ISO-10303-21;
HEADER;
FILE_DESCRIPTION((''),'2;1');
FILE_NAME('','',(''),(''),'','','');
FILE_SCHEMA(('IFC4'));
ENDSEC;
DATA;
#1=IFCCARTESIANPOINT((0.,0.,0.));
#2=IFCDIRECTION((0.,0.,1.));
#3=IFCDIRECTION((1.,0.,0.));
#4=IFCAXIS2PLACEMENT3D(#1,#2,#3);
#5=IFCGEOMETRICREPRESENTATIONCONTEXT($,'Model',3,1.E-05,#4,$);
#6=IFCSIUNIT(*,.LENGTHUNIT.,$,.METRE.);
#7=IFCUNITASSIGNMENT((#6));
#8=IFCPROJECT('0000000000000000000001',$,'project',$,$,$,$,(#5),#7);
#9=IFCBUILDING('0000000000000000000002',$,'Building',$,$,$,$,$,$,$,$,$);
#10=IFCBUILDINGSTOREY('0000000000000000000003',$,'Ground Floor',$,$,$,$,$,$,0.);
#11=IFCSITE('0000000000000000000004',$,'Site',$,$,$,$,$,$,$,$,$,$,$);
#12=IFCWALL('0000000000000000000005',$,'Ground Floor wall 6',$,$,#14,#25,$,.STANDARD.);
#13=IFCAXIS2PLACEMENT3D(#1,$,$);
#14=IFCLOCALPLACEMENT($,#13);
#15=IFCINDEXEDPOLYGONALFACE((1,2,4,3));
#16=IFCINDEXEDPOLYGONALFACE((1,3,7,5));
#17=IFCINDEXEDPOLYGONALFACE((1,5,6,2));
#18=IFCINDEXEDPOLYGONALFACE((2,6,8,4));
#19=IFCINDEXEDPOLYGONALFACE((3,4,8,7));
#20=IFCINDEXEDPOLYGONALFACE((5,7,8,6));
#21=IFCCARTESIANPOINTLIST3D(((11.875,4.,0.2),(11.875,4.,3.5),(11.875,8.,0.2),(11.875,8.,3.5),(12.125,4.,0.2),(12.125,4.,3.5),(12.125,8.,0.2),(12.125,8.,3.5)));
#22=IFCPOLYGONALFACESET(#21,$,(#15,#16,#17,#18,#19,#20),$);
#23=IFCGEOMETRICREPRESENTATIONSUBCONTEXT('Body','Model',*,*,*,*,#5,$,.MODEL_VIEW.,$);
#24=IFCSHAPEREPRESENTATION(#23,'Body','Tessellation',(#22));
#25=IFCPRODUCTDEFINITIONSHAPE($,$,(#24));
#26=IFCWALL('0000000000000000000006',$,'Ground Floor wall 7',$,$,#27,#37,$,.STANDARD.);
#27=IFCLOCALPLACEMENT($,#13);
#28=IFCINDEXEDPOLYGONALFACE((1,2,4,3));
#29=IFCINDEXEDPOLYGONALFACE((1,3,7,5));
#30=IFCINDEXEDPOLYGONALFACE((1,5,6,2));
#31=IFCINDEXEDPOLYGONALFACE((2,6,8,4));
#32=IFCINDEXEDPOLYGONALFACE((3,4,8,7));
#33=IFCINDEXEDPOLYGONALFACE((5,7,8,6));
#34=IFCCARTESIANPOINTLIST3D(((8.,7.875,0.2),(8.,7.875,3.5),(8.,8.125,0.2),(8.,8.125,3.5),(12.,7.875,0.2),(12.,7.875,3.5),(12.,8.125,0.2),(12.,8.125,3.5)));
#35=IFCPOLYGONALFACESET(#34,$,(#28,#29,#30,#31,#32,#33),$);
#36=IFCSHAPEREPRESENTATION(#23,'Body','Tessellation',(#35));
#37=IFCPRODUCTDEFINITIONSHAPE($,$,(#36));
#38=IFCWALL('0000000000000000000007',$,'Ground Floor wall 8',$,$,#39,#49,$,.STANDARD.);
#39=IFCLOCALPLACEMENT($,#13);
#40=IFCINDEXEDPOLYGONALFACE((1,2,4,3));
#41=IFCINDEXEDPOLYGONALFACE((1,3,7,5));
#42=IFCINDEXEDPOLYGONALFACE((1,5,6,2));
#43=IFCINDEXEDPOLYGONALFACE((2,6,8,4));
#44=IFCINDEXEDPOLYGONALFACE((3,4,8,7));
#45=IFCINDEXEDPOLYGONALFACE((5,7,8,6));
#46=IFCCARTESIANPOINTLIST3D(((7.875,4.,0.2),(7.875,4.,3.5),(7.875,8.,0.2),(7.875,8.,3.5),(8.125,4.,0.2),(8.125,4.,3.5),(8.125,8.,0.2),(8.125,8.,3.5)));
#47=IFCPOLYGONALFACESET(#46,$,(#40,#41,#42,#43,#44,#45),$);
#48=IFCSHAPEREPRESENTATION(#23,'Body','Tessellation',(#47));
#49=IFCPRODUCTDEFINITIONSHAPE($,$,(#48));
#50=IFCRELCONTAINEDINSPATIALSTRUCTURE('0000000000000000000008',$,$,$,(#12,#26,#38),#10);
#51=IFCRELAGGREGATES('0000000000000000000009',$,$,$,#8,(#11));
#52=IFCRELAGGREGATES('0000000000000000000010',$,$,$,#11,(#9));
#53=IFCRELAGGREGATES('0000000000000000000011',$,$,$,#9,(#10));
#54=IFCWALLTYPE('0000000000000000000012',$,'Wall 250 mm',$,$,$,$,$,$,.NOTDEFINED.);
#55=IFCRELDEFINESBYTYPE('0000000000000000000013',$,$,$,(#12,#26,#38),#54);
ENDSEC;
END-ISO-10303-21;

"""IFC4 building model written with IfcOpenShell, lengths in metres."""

from ifc_helpers import new_model, si_unit, frame, origin_with_axes, place, context, subcontext, project, spatial, indexed_curve, outline, extrude, type_object, element, save


model = new_model("IFC4")

# Units and contexts
model_context = context("Model", 3, precision=1e-05, world=origin_with_axes())
body_context = subcontext(model_context, "Body", "Model", "MODEL_VIEW")
ifc_project = project(units=[si_unit("LENGTHUNIT", "METRE")], contexts=[model_context])

# Site, building, storey
site = spatial("IfcSite", under=ifc_project, Name="Site")
building = spatial("IfcBuilding", under=site, Name="Building")
storey = spatial("IfcBuildingStorey", under=building, Name="Ground Floor", Elevation=0.0)

# Walls
wall_type_1 = type_object("IfcWallType", Name="Wall 250 mm", PredefinedType="NOTDEFINED")
for number, where, z_axis, x_axis, name in (
    (1, (12.0, 4.0, 0.2), (0.0, 0.0, 1.0), (0.0, 1.0, 0.0), "Ground Floor wall 6"),
    (2, (12.0, 8.0, 0.2), (0.0, 0.0, 1.0), (-1.0, 0.0, 0.0), "Ground Floor wall 7"),
    (3, (8.0, 8.0, 0.2), (0.0, 0.0, 1.0), (0.0, -1.0, 0.0), "Ground Floor wall 8"),
):
    element("IfcWall", number, at=place(None, frame(where, z_axis=z_axis, x_axis=x_axis)), inside=storey, type_object=wall_type_1, Name=name, PredefinedType="STANDARD", context=body_context, shape_type="SweptSolid", body=[
        extrude(outline(indexed_curve([(0.0, 0.0), (0.0, 0.25), (4.0, 0.25), (4.0, 0.0), (0.0, 0.0)], self_intersect=False)), frame((0.0, -0.125, 0.0), z_axis=(0.0, 0.0, 1.0), x_axis=(1.0, 0.0, 0.0)), (0.0, 0.0, 1.0), 3.3),
    ])

save(model, "model.ifc")
